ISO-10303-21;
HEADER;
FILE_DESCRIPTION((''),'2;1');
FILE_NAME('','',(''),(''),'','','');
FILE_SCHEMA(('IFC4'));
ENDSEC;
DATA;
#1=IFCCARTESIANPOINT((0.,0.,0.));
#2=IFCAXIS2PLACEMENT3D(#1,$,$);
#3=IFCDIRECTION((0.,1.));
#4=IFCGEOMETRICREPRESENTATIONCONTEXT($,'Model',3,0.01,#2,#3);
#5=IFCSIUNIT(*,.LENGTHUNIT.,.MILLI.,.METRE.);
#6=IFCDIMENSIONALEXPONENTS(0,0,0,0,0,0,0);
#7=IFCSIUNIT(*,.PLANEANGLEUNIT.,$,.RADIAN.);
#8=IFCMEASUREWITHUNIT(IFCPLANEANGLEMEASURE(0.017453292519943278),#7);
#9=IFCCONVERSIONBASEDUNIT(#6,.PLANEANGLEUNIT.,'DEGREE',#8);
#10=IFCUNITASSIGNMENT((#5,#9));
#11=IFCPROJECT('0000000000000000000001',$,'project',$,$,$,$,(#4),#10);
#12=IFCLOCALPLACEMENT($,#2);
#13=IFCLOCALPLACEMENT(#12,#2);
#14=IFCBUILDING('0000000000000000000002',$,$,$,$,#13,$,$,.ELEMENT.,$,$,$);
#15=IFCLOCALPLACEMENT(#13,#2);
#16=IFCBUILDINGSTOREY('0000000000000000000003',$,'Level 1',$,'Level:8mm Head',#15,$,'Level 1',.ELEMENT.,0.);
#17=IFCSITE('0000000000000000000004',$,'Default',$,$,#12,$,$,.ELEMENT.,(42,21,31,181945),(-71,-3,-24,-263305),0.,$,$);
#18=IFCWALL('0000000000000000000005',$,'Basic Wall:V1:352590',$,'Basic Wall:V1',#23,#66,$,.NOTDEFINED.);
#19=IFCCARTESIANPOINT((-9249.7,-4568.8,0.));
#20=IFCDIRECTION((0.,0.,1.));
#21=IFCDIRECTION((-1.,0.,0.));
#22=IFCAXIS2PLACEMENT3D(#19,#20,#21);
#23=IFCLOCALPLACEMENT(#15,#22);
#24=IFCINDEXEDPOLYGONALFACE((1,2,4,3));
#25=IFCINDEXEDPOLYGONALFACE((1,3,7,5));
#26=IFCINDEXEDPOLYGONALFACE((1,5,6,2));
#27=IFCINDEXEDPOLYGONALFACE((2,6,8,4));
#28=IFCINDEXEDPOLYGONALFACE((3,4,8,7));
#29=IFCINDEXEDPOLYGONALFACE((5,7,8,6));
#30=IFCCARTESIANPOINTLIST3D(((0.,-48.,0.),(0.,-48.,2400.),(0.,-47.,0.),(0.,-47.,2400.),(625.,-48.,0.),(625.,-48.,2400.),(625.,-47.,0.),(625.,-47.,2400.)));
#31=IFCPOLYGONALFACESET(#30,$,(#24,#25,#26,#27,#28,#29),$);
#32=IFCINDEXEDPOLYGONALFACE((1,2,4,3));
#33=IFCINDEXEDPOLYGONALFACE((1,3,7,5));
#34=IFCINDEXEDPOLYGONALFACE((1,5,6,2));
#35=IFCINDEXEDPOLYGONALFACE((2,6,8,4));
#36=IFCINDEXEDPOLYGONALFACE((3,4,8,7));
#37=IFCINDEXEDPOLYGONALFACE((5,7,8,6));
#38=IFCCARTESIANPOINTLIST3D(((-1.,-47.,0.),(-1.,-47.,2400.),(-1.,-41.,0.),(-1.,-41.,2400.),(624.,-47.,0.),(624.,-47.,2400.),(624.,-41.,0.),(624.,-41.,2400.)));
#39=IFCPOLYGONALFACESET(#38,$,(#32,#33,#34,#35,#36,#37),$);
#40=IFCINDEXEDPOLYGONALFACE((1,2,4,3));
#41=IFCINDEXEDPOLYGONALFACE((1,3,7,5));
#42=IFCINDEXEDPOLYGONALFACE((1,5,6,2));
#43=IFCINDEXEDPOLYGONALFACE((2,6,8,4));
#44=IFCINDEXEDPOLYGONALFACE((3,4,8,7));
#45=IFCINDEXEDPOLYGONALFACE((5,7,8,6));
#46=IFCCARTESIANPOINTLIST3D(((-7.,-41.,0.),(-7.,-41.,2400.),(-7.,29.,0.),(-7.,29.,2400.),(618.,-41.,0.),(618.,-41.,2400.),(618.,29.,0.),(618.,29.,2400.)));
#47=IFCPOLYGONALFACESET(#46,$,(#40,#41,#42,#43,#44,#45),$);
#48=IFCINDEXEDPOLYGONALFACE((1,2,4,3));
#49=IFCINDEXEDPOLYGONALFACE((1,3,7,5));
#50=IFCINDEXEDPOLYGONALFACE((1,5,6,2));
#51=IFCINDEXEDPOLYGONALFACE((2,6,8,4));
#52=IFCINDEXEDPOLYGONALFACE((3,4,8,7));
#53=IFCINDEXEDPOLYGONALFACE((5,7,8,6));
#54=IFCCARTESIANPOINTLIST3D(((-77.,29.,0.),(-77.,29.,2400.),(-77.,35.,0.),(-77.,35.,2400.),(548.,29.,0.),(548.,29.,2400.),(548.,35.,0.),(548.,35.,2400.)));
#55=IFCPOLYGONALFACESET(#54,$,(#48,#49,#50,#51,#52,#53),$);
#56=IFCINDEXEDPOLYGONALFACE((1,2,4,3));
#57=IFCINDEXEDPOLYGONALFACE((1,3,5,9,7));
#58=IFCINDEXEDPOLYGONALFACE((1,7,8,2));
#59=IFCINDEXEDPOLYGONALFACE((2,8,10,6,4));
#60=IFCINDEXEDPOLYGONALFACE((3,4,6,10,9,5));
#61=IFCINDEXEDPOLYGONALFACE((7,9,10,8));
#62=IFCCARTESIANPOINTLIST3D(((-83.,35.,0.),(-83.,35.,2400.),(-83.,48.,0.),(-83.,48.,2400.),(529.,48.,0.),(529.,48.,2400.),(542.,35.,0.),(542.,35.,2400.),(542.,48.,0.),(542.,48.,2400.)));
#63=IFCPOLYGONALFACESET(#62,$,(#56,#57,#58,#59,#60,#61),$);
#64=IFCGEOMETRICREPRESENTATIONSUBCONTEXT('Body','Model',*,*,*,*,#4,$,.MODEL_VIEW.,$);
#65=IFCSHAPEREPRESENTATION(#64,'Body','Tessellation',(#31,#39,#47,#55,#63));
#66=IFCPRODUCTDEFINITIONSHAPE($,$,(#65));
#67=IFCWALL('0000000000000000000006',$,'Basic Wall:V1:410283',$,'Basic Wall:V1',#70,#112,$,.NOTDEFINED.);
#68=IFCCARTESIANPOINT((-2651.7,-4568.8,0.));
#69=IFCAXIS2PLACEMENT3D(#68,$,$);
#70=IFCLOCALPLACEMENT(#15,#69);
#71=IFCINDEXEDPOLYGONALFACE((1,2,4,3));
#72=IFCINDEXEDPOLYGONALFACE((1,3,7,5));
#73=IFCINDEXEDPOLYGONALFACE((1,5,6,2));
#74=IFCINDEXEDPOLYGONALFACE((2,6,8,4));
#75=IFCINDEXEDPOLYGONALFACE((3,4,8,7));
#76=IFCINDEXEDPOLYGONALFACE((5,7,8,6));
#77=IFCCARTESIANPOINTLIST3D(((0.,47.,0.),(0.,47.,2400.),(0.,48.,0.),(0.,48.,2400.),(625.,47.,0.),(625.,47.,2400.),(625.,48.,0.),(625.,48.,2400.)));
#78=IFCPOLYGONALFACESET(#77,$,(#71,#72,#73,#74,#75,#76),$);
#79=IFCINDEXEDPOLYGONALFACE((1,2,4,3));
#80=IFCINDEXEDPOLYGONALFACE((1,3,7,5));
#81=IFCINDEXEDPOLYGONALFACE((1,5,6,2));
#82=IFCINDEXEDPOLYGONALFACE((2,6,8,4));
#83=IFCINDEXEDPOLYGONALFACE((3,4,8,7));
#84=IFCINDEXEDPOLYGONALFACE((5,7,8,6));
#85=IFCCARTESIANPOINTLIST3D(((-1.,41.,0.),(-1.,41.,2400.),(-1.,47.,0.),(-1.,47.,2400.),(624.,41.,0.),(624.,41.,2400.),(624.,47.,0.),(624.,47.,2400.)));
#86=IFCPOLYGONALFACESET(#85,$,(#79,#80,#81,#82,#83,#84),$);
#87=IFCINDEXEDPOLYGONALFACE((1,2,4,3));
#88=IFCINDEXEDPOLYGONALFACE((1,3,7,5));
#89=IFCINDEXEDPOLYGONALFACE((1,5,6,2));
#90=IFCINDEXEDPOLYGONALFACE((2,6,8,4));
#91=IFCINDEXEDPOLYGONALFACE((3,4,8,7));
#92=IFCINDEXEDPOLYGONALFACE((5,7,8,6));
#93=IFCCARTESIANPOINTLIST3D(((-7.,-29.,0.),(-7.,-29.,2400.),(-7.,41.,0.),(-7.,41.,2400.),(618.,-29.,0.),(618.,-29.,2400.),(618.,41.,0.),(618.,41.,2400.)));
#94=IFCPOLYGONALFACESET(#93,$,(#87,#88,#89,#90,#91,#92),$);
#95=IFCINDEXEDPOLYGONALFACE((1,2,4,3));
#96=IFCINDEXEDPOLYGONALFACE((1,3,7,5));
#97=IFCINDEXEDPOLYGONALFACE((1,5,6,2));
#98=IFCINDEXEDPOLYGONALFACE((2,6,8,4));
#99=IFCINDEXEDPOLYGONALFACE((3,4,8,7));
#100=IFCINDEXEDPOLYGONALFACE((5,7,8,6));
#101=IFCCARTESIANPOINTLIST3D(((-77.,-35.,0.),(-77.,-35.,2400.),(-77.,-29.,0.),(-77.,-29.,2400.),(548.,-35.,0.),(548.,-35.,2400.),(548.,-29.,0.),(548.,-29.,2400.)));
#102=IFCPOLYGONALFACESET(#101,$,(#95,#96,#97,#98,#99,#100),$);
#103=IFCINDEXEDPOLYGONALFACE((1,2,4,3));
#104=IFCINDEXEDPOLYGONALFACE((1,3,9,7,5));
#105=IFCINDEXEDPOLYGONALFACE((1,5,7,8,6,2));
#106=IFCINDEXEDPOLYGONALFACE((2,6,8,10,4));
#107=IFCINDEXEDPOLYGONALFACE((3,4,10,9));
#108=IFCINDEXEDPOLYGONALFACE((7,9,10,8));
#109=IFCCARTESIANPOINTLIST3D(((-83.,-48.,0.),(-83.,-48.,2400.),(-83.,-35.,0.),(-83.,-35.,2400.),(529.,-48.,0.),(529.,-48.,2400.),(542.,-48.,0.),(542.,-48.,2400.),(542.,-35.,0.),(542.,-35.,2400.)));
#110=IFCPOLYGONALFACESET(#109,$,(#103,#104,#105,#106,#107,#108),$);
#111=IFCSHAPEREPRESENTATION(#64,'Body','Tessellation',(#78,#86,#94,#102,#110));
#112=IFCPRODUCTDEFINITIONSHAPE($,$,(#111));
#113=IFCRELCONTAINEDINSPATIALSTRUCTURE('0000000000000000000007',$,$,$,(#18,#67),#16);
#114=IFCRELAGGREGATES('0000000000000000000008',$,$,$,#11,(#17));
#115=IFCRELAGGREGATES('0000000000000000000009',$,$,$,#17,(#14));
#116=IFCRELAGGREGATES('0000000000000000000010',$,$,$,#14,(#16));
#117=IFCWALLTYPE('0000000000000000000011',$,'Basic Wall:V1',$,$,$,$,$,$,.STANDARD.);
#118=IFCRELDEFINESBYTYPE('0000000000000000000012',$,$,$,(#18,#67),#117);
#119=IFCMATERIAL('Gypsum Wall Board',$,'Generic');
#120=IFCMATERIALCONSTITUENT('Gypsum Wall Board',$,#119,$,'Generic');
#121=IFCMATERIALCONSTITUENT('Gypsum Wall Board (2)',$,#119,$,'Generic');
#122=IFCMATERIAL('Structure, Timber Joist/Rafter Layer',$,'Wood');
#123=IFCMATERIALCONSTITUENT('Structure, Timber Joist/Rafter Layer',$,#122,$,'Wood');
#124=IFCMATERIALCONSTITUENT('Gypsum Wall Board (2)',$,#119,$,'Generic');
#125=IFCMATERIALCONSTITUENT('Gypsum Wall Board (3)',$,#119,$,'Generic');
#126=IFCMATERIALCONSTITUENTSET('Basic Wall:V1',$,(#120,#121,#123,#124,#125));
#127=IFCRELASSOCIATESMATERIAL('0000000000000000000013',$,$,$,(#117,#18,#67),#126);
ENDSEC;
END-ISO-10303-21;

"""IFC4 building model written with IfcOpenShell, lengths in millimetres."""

from ifc_helpers import new_model, entity, si_unit, converted_unit, direction, frame, origin, place, context, subcontext, project, spatial, indexed_curve, outline, extrude, material, constituent, constituent_set, type_object, element, save


model = new_model("IFC4")

# Units and contexts
model_context = context("Model", 3, precision=0.01, world=origin(), true_north=direction((0.0, 1.0)))
body_context = subcontext(model_context, "Body", "Model", "MODEL_VIEW")
ifc_project = project(units=[si_unit("LENGTHUNIT", "METRE", prefix="MILLI"), converted_unit("PLANEANGLEUNIT", "DEGREE", entity("IfcPlaneAngleMeasure", 0.017453292519943278), si_unit("PLANEANGLEUNIT", "RADIAN"), dimensions=[0, 0, 0, 0, 0, 0, 0])], contexts=[model_context])

# Site, building, storey
site_placement = place(None, origin())
site = spatial("IfcSite", under=ifc_project, at=site_placement, Name="Default", CompositionType="ELEMENT", RefLatitude=(42, 21, 31, 181945), RefLongitude=(-71, -3, -24, -263305), RefElevation=0.0)
building_placement = place(site_placement, origin())
building = spatial("IfcBuilding", under=site, at=building_placement, CompositionType="ELEMENT")
storey_placement = place(building_placement, origin())
storey = spatial("IfcBuildingStorey", under=building, at=storey_placement, Name="Level 1", ObjectType="Level:8mm Head", LongName="Level 1", CompositionType="ELEMENT", Elevation=0.0)

# Walls
ifc_material_1 = material(Name="Gypsum Wall Board", Category="Generic")
ifc_constituent_1 = constituent(ifc_material_1, Name="Gypsum Wall Board", Category="Generic")
ifc_constituent_2 = constituent(ifc_material_1, Name="Gypsum Wall Board (2)", Category="Generic")
ifc_material_2 = material(Name="Structure, Timber Joist/Rafter Layer", Category="Wood")
ifc_constituent_3 = constituent(ifc_material_2, Name="Structure, Timber Joist/Rafter Layer", Category="Wood")
ifc_constituent_4 = constituent(ifc_material_1, Name="Gypsum Wall Board (2)", Category="Generic")
ifc_constituent_5 = constituent(ifc_material_1, Name="Gypsum Wall Board (3)", Category="Generic")
ifc_constituent_set_1 = constituent_set(constituents=[ifc_constituent_1, ifc_constituent_2, ifc_constituent_3, ifc_constituent_4, ifc_constituent_5], Name="Basic Wall:V1")
wall_type_1 = type_object("IfcWallType", Name="Basic Wall:V1", PredefinedType="STANDARD", material=ifc_constituent_set_1)
wall_1_placement = place(storey_placement, frame((-9249.7, -4568.8, 0.0), z_axis=(0.0, 0.0, 1.0), x_axis=(-1.0, 0.0, 0.0)))
element("IfcWall", 1, at=wall_1_placement, inside=storey, type_object=wall_type_1, material=ifc_constituent_set_1, Name="Basic Wall:V1:352590", ObjectType="Basic Wall:V1", PredefinedType="NOTDEFINED", context=body_context, shape_type="SweptSolid", body=[
    extrude(outline(indexed_curve([(-0.5, -312.5), (0.5, -312.5), (0.5, 312.5), (-0.5, 312.5), (-0.5, -312.5)], self_intersect=False)), frame((312.5, -47.5, 0.0), z_axis=(0.0, 0.0, 1.0), x_axis=(0.0, 1.0, 0.0)), (0.0, 0.0, 1.0), 2400.0),
    extrude(outline(indexed_curve([(-312.5, -3.0), (312.5, -3.0), (312.5, 3.0), (-312.5, 3.0), (-312.5, -3.0)], self_intersect=False)), frame((311.5, -44.0, 0.0)), (0.0, 0.0, 1.0), 2400.0),
    extrude(outline(indexed_curve([(-312.5, -35.0), (312.5, -35.0), (312.5, 35.0), (-312.5, 35.0), (-312.5, -35.0)], self_intersect=False)), frame((305.5, -6.0, 0.0)), (0.0, 0.0, 1.0), 2400.0),
    extrude(outline(indexed_curve([(-312.5, -3.0), (312.5, -3.0), (312.5, 3.0), (-312.5, 3.0), (-312.5, -3.0)], self_intersect=False)), frame((235.5, 32.0, 0.0)), (0.0, 0.0, 1.0), 2400.0),
    extrude(outline(indexed_curve([(-239.6, -5.2), (372.4, -5.2), (372.4, 7.8), (-252.6, 7.8), (-252.6, -5.2), (-239.6, -5.2)], self_intersect=False)), frame((289.4, 42.8, 0.0), z_axis=(0.0, 0.0, 1.0), x_axis=(-1.0, 0.0, 0.0)), (0.0, 0.0, 1.0), 2400.0),
])
wall_2_placement = place(storey_placement, frame((-2651.7, -4568.8, 0.0)))
element("IfcWall", 2, at=wall_2_placement, inside=storey, type_object=wall_type_1, material=ifc_constituent_set_1, Name="Basic Wall:V1:410283", ObjectType="Basic Wall:V1", PredefinedType="NOTDEFINED", context=body_context, shape_type="SweptSolid", body=[
    extrude(outline(indexed_curve([(-0.5, -312.5), (0.5, -312.5), (0.5, 312.5), (-0.5, 312.5), (-0.5, -312.5)], self_intersect=False)), frame((312.5, 47.5, 0.0), z_axis=(0.0, 0.0, 1.0), x_axis=(0.0, -1.0, 0.0)), (0.0, 0.0, 1.0), 2400.0),
    extrude(outline(indexed_curve([(-312.5, -3.0), (312.5, -3.0), (312.5, 3.0), (-312.5, 3.0), (-312.5, -3.0)], self_intersect=False)), frame((311.5, 44.0, 0.0)), (0.0, 0.0, 1.0), 2400.0),
    extrude(outline(indexed_curve([(-312.5, -35.0), (312.5, -35.0), (312.5, 35.0), (-312.5, 35.0), (-312.5, -35.0)], self_intersect=False)), frame((305.5, 6.0, 0.0)), (0.0, 0.0, 1.0), 2400.0),
    extrude(outline(indexed_curve([(-312.5, -3.0), (312.5, -3.0), (312.5, 3.0), (-312.5, 3.0), (-312.5, -3.0)], self_intersect=False)), frame((235.5, -32.0, 0.0)), (0.0, 0.0, 1.0), 2400.0),
    extrude(outline(indexed_curve([(239.6, -5.2), (252.6, -5.2), (252.6, 7.8), (-372.4, 7.8), (-372.4, -5.2), (239.6, -5.2)], self_intersect=False)), frame((289.4, -42.8, 0.0)), (0.0, 0.0, 1.0), 2400.0),
])

save(model, "model.ifc")
